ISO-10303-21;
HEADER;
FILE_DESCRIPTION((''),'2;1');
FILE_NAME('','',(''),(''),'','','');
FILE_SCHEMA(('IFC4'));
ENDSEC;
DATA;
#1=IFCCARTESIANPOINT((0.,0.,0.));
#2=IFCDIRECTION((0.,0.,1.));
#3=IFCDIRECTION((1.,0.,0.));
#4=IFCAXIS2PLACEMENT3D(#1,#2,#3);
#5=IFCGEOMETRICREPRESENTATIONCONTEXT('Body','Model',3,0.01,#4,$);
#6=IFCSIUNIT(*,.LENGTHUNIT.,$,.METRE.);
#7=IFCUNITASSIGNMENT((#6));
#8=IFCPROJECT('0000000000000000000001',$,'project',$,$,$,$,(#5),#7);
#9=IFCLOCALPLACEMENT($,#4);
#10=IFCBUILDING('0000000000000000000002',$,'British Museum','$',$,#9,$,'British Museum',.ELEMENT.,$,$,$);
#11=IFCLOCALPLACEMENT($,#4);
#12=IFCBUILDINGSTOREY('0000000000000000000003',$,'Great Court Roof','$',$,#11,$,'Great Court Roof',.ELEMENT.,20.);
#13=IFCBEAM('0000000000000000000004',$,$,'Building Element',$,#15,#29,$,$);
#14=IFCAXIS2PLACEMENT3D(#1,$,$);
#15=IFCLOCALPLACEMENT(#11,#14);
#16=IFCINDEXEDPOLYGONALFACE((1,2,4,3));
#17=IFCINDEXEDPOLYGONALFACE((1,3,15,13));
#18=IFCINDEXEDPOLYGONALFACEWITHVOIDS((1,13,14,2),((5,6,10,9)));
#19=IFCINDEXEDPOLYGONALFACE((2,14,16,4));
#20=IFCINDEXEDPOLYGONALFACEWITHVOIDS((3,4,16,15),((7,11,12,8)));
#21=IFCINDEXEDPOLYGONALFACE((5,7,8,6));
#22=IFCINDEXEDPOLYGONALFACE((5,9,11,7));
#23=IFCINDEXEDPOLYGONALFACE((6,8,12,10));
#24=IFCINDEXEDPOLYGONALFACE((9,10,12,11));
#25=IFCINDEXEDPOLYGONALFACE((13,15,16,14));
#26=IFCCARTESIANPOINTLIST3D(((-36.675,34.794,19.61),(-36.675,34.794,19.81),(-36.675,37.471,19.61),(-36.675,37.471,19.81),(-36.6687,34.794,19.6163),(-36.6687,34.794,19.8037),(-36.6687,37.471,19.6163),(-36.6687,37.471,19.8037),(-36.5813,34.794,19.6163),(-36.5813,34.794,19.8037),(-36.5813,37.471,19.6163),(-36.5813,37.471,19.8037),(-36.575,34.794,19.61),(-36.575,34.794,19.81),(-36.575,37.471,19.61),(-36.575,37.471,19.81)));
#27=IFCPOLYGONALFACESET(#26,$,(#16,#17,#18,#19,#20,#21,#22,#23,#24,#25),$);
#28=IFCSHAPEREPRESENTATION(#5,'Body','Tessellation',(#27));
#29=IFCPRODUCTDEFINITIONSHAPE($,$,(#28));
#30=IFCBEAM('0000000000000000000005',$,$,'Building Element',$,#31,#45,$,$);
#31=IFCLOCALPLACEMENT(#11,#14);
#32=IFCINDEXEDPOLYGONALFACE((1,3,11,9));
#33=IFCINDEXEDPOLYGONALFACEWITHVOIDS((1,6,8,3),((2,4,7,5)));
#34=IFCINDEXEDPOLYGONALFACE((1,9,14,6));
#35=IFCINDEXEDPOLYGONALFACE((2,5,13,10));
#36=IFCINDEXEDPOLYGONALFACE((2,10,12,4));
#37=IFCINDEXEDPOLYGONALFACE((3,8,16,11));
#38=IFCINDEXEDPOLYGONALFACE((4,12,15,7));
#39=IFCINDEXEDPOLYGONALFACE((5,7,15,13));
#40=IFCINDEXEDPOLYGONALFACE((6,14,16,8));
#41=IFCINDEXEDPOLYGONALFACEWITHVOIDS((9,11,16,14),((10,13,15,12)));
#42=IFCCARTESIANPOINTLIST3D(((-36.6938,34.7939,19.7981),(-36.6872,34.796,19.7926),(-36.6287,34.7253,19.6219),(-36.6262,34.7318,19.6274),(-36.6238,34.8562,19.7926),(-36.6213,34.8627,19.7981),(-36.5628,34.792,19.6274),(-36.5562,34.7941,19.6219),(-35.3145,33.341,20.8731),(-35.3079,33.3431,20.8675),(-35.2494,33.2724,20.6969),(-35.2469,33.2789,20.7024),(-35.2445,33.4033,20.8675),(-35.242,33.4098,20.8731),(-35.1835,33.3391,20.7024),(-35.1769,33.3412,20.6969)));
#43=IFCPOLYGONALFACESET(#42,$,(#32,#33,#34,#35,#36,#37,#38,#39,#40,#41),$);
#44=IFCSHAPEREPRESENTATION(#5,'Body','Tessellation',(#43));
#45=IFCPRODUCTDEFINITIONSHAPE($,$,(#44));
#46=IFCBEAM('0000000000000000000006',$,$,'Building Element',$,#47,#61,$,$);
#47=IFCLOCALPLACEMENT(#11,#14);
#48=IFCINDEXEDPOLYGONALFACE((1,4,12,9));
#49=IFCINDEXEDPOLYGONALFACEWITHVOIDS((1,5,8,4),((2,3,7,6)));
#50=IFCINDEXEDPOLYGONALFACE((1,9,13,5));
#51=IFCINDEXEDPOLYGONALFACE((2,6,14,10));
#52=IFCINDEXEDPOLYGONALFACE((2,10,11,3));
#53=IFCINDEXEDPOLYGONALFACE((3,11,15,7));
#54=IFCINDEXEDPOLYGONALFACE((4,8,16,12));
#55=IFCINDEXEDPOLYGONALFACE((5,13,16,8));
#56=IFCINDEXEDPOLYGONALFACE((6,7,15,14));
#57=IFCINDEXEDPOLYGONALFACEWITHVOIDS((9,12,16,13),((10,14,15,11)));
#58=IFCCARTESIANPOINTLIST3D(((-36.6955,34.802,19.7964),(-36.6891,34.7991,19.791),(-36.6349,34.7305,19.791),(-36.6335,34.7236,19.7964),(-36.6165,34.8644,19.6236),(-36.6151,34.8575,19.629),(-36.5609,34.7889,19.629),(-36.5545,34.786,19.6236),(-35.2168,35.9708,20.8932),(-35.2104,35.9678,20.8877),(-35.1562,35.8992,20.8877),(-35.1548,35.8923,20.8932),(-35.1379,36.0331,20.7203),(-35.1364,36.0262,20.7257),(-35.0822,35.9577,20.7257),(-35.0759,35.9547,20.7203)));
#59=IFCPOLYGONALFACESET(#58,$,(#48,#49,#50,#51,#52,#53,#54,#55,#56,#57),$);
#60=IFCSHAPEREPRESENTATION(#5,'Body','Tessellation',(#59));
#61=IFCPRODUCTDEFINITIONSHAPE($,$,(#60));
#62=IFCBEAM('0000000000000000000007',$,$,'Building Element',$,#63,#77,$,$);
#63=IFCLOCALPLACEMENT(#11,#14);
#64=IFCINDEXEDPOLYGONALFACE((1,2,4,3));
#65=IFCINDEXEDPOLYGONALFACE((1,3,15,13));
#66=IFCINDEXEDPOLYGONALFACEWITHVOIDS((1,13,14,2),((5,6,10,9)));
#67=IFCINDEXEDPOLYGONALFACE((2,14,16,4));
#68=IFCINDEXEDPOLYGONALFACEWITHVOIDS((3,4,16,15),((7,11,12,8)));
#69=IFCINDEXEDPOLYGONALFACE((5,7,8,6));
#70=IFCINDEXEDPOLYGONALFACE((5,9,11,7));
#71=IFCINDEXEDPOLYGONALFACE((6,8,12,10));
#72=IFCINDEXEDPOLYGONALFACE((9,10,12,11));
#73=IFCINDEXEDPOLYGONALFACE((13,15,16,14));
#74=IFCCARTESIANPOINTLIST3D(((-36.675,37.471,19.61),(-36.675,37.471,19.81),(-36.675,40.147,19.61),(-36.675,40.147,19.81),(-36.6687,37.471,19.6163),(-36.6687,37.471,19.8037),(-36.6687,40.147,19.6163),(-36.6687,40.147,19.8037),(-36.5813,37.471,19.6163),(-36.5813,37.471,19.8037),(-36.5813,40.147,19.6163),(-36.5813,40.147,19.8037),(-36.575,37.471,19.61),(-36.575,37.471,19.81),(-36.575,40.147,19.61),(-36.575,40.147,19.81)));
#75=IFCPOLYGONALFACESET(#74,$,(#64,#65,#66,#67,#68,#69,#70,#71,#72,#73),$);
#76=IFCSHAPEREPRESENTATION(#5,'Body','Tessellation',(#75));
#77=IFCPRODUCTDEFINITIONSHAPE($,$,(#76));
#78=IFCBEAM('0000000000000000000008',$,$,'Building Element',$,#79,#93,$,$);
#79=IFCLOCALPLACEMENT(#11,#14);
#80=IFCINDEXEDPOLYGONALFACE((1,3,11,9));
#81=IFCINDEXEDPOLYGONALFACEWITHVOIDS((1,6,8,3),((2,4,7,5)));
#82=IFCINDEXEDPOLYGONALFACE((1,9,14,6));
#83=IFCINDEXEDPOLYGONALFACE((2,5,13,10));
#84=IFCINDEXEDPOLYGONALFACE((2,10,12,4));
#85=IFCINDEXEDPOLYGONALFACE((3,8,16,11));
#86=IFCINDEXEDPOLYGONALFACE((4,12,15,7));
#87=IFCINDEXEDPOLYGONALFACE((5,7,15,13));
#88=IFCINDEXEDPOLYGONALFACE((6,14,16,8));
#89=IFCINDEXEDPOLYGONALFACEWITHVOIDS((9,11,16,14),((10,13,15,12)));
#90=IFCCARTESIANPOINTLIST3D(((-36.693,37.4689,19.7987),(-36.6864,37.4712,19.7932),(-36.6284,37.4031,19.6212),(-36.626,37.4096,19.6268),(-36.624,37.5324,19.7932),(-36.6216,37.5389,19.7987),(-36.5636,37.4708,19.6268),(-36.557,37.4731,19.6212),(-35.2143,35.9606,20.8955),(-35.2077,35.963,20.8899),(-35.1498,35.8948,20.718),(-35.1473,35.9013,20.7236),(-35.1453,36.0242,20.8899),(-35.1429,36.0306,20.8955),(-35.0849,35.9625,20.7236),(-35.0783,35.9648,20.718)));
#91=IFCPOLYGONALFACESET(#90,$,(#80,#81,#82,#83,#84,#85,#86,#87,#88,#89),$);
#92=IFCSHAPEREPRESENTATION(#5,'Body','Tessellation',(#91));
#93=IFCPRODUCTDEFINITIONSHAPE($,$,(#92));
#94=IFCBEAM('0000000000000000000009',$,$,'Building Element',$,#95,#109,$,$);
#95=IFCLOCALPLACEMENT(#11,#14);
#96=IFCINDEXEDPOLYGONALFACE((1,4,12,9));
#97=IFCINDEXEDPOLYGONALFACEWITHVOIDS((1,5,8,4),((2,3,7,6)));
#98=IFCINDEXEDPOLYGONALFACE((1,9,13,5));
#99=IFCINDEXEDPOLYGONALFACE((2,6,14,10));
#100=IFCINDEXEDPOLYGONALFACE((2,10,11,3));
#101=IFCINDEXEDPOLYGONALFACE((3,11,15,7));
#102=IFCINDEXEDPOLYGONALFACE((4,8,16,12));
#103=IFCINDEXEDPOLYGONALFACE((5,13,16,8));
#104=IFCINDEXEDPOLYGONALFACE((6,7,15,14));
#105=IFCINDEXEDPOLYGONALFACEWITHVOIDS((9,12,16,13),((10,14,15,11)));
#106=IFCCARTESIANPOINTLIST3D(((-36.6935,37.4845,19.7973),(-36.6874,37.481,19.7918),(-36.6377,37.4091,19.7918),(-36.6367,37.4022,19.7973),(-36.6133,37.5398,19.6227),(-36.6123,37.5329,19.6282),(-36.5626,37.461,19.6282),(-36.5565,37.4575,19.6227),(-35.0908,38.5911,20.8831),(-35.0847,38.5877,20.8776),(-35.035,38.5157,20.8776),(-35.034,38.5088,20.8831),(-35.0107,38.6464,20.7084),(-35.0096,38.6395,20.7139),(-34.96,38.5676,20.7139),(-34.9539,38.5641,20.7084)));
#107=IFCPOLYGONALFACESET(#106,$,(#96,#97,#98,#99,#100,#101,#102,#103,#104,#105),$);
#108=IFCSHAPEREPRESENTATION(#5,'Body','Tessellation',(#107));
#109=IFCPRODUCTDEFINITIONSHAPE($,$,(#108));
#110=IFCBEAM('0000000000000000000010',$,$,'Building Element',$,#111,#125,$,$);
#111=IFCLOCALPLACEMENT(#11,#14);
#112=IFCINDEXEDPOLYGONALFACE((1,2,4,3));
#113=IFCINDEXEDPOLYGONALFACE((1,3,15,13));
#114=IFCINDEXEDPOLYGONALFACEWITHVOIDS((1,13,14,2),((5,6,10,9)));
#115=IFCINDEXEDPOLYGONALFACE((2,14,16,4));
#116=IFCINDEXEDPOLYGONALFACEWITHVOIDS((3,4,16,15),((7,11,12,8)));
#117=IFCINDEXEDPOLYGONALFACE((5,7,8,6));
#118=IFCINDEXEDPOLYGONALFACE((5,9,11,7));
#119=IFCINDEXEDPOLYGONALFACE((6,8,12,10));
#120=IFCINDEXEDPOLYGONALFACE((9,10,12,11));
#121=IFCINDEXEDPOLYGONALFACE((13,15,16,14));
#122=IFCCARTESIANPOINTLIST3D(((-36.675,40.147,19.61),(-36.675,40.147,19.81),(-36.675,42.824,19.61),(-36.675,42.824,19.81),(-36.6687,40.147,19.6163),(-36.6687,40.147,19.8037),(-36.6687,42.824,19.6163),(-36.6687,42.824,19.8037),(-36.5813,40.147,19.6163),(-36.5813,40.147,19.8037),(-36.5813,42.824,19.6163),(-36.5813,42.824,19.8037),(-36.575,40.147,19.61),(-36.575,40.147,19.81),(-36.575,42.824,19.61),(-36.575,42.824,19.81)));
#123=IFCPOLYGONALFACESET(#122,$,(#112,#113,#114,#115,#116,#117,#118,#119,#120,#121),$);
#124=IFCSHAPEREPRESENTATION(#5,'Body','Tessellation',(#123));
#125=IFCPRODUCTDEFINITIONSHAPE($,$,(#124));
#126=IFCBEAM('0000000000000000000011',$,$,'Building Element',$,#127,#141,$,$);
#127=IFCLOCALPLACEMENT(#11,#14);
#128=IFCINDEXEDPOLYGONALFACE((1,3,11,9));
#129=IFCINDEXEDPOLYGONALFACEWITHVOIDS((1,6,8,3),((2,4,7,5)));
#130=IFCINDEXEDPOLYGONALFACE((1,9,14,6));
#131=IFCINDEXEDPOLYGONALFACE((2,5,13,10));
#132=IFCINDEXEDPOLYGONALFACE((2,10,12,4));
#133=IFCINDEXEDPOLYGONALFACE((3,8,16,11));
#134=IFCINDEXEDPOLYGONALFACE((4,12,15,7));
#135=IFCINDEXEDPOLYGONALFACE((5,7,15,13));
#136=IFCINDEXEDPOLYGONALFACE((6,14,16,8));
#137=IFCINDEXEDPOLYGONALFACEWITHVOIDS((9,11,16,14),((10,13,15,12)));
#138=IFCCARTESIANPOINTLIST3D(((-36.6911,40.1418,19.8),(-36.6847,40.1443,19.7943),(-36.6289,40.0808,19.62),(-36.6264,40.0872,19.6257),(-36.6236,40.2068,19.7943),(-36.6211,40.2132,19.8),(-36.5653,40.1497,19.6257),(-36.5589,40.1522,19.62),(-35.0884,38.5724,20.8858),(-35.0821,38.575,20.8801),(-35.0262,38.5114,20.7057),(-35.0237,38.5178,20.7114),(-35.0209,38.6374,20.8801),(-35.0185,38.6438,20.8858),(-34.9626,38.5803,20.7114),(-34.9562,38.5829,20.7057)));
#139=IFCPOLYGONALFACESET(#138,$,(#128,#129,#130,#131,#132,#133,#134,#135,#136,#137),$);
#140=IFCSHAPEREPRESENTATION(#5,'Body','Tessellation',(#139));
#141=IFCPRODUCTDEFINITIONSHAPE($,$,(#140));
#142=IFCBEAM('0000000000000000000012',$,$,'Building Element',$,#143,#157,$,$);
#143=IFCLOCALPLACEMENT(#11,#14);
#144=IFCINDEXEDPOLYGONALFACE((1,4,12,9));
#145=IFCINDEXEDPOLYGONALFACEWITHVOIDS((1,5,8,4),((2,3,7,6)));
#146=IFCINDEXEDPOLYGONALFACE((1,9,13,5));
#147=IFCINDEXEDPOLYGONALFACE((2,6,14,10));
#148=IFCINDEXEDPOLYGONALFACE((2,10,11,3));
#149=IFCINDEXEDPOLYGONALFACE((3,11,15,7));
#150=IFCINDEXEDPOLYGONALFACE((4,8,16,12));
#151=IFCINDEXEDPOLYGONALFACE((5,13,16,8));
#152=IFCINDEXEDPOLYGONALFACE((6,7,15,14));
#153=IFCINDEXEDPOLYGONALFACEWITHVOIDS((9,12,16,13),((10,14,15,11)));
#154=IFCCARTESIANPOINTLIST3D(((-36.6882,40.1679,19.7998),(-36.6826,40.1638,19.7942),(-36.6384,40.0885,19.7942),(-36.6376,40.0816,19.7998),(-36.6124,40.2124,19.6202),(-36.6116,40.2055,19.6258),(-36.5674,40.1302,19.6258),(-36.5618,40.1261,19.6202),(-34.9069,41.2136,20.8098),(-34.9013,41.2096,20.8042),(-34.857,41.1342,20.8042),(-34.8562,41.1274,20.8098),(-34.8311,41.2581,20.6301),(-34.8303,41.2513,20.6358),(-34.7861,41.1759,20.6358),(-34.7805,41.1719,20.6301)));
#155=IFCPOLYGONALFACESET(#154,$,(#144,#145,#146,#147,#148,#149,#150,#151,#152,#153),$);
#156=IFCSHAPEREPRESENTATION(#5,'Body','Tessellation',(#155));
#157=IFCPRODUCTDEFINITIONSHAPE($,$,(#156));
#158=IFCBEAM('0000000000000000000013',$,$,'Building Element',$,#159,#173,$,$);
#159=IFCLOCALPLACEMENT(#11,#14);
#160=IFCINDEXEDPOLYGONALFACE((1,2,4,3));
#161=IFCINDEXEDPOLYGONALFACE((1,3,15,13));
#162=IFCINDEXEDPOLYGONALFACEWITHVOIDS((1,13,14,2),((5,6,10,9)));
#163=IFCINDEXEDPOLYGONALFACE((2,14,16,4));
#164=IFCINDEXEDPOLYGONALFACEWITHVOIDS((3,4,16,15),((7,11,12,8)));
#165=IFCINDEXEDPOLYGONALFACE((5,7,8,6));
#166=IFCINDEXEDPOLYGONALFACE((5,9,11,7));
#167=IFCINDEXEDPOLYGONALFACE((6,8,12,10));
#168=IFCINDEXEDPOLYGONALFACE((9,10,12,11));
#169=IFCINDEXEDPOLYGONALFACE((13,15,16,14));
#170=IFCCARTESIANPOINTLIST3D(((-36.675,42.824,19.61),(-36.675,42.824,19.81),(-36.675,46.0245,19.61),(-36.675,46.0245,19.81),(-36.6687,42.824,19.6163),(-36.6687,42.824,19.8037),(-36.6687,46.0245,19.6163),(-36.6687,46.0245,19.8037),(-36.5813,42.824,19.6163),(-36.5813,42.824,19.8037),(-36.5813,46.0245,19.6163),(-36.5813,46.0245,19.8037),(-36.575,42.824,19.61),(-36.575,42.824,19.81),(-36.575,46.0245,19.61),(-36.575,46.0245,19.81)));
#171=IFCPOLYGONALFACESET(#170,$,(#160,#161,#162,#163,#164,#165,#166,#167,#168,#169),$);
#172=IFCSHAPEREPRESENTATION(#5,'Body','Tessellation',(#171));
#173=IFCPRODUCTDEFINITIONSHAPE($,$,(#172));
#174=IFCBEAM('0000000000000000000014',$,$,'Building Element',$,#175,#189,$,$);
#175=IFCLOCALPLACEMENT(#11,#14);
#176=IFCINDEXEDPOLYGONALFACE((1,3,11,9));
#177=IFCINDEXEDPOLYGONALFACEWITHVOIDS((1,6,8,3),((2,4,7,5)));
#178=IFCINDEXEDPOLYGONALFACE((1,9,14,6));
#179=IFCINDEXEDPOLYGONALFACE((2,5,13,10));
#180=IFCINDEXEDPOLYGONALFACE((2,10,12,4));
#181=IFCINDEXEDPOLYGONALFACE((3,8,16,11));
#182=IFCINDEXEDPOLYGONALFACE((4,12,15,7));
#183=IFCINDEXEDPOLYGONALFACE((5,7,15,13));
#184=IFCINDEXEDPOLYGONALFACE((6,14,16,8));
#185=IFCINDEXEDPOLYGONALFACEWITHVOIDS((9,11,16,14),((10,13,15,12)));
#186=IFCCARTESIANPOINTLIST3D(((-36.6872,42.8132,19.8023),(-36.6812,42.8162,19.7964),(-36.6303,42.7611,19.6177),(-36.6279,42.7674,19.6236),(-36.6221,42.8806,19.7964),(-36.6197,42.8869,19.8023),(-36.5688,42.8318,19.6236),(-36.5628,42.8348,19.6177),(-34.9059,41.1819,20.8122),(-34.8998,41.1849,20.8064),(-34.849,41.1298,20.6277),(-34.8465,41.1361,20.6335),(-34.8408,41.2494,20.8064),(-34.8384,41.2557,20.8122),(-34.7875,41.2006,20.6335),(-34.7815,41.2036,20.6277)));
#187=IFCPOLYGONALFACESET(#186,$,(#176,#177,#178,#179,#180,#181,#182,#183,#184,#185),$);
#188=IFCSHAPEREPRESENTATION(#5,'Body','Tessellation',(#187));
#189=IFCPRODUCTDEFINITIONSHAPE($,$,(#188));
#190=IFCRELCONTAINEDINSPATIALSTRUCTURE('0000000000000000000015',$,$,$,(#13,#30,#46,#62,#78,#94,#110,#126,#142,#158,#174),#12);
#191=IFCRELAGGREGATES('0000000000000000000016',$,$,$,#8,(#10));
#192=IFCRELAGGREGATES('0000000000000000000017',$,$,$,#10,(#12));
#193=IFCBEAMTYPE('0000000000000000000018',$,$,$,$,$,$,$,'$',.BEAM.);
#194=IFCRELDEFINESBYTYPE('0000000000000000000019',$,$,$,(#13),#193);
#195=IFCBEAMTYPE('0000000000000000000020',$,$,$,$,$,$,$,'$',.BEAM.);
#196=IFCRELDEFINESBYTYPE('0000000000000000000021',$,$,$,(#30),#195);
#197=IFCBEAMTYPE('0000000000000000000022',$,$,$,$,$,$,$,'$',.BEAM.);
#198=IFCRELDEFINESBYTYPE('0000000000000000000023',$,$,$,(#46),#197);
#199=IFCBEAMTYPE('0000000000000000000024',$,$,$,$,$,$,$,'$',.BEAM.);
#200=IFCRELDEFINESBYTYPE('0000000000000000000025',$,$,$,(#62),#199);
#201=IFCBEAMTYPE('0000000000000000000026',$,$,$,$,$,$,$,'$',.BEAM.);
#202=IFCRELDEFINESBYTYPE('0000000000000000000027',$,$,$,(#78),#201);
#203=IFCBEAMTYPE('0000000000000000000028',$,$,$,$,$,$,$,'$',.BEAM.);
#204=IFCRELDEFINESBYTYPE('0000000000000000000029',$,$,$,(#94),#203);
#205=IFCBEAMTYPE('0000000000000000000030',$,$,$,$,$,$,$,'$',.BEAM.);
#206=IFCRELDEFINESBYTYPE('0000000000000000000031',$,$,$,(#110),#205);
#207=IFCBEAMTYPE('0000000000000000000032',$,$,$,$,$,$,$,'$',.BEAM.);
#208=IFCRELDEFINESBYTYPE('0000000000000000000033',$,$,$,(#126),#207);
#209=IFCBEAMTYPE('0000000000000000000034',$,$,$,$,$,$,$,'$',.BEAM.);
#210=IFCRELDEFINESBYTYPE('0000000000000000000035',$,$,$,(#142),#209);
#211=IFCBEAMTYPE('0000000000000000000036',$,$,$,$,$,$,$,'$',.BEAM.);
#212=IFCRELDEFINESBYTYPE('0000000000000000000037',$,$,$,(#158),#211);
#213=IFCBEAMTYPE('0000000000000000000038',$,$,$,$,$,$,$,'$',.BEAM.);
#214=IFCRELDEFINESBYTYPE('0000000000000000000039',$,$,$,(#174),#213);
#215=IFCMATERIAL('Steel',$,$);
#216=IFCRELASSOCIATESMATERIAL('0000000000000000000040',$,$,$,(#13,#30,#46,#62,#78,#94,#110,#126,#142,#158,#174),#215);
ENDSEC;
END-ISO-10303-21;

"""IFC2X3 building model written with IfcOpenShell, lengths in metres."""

from ifc_helpers import new_model, si_unit, frame, origin_with_axes, origin_2d, place, context, project, spatial, hollow_rectangle, extrude, material, type_object, element, save


model = new_model("IFC2X3")

# Units and contexts
model_context = context("Model", 3, precision=0.01, world=origin_with_axes(), identifier="Body")
ifc_project = project(units=[si_unit("LENGTHUNIT", "METRE")], contexts=[model_context])

# Building, storey
building_placement = place(None, origin_with_axes())
building = spatial("IfcBuilding", under=ifc_project, at=building_placement, Name="British Museum", Description="$", LongName="British Museum", CompositionType="ELEMENT")
storey_placement = place(None, origin_with_axes())
storey = spatial("IfcBuildingStorey", under=building, at=storey_placement, Name="Great Court Roof", Description="$", LongName="Great Court Roof", CompositionType="ELEMENT", Elevation=20.0)

# Beams
ifc_material = material(Name="Steel")
beam_type_1 = type_object("IfcBeamType", ElementType="$", PredefinedType="BEAM")
beam_1_placement = place(None, origin_with_axes())
element("IfcBeam", 1, at=beam_1_placement, inside=storey, type_object=beam_type_1, material=ifc_material, Description="Building Element", context=model_context, shape_type="SweptSolid", body=[
    extrude(hollow_rectangle(XDim=0.1, YDim=0.2, WallThickness=0.0063, InnerFilletRadius=-0.0063, OuterFilletRadius=0.0, at=origin_2d()), frame((-36.625, 34.794, 19.71), z_axis=(0.0, 1.0, 0.0), x_axis=(-1.0, 0.0, 0.0)), (0.0, 0.0, 1.0), 2.677),
])
beam_type_2 = type_object("IfcBeamType", ElementType="$", PredefinedType="BEAM")
beam_2_placement = place(None, origin_with_axes())
element("IfcBeam", 2, at=beam_2_placement, inside=storey, type_object=beam_type_2, material=ifc_material, Description="Building Element", context=model_context, shape_type="SweptSolid", body=[
    extrude(hollow_rectangle(XDim=0.1, YDim=0.2, WallThickness=0.0063, InnerFilletRadius=-0.0063, OuterFilletRadius=0.0, at=origin_2d()), frame((-36.625, 34.794, 19.71), z_axis=(0.606687, -0.639042, 0.472818), x_axis=(0.725228, 0.688509, 0.0)), (0.0, 0.0, 1.0), 2.2735),
])
beam_type_3 = type_object("IfcBeamType", ElementType="$", PredefinedType="BEAM")
beam_3_placement = place(None, origin_with_axes())
element("IfcBeam", 3, at=beam_3_placement, inside=storey, type_object=beam_type_3, material=ifc_material, Description="Building Element", context=model_context, shape_type="SweptSolid", body=[
    extrude(hollow_rectangle(XDim=0.1, YDim=0.2, WallThickness=0.0063, InnerFilletRadius=-0.0063, OuterFilletRadius=0.0, at=origin_2d()), frame((-36.625, 34.794, 19.71), z_axis=(0.678093, 0.535954, 0.502935), x_axis=(-0.620084, 0.784535, 0.0)), (0.0, 0.0, 1.0), 2.1807),
])
beam_type_4 = type_object("IfcBeamType", ElementType="$", PredefinedType="BEAM")
beam_4_placement = place(None, origin_with_axes())
element("IfcBeam", 4, at=beam_4_placement, inside=storey, type_object=beam_type_4, material=ifc_material, Description="Building Element", context=model_context, shape_type="SweptSolid", body=[
    extrude(hollow_rectangle(XDim=0.1, YDim=0.2, WallThickness=0.0063, InnerFilletRadius=-0.0063, OuterFilletRadius=0.0, at=origin_2d()), frame((-36.625, 37.471, 19.71), z_axis=(0.0, 1.0, 0.0), x_axis=(-1.0, 0.0, 0.0)), (0.0, 0.0, 1.0), 2.676),
])
beam_type_5 = type_object("IfcBeamType", ElementType="$", PredefinedType="BEAM")
beam_5_placement = place(None, origin_with_axes())
element("IfcBeam", 5, at=beam_5_placement, inside=storey, type_object=beam_type_5, material=ifc_material, Description="Building Element", context=model_context, shape_type="SweptSolid", body=[
    extrude(hollow_rectangle(XDim=0.1, YDim=0.2, WallThickness=0.0063, InnerFilletRadius=-0.0063, OuterFilletRadius=0.0, at=origin_2d()), frame((-36.625, 37.471, 19.71), z_axis=(0.621307, -0.633738, 0.460818), x_axis=(0.714075, 0.700069, 0.0)), (0.0, 0.0, 1.0), 2.38),
])
beam_type_6 = type_object("IfcBeamType", ElementType="$", PredefinedType="BEAM")
beam_6_placement = place(None, origin_with_axes())
element("IfcBeam", 6, at=beam_6_placement, inside=storey, type_object=beam_type_6, material=ifc_material, Description="Building Element", context=model_context, shape_type="SweptSolid", body=[
    extrude(hollow_rectangle(XDim=0.1, YDim=0.2, WallThickness=0.0063, InnerFilletRadius=-0.0063, OuterFilletRadius=0.0, at=origin_2d()), frame((-36.625, 37.471, 19.71), z_axis=(0.718752, 0.496287, 0.486924), x_axis=(-0.568195, 0.822894, 0.0)), (0.0, 0.0, 1.0), 2.2298),
])
beam_type_7 = type_object("IfcBeamType", ElementType="$", PredefinedType="BEAM")
beam_7_placement = place(None, origin_with_axes())
element("IfcBeam", 7, at=beam_7_placement, inside=storey, type_object=beam_type_7, material=ifc_material, Description="Building Element", context=model_context, shape_type="SweptSolid", body=[
    extrude(hollow_rectangle(XDim=0.1, YDim=0.2, WallThickness=0.0063, InnerFilletRadius=-0.0063, OuterFilletRadius=0.0, at=origin_2d()), frame((-36.625, 40.147, 19.71), z_axis=(0.0, 1.0, 0.0), x_axis=(-1.0, 0.0, 0.0)), (0.0, 0.0, 1.0), 2.677),
])
beam_type_8 = type_object("IfcBeamType", ElementType="$", PredefinedType="BEAM")
beam_8_placement = place(None, origin_with_axes())
element("IfcBeam", 8, at=beam_8_placement, inside=storey, type_object=beam_type_8, material=ifc_material, Description="Building Element", context=model_context, shape_type="SweptSolid", body=[
    extrude(hollow_rectangle(XDim=0.1, YDim=0.2, WallThickness=0.0063, InnerFilletRadius=-0.0063, OuterFilletRadius=0.0, at=origin_2d()), frame((-36.625, 40.147, 19.71), z_axis=(0.643111, -0.629754, 0.435681), x_axis=(0.699648, 0.714488, 0.0)), (0.0, 0.0, 1.0), 2.4921),
])
beam_type_9 = type_object("IfcBeamType", ElementType="$", PredefinedType="BEAM")
beam_9_placement = place(None, origin_with_axes())
element("IfcBeam", 9, at=beam_9_placement, inside=storey, type_object=beam_type_9, material=ifc_material, Description="Building Element", context=model_context, shape_type="SweptSolid", body=[
    extrude(hollow_rectangle(XDim=0.1, YDim=0.2, WallThickness=0.0063, InnerFilletRadius=-0.0063, OuterFilletRadius=0.0, at=origin_2d()), frame((-36.625, 40.147, 19.71), z_axis=(0.774727, 0.454812, 0.439255), x_axis=(-0.506267, 0.862377, 0.0)), (0.0, 0.0, 1.0), 2.2993),
])
beam_type_10 = type_object("IfcBeamType", ElementType="$", PredefinedType="BEAM")
beam_10_placement = place(None, origin_with_axes())
element("IfcBeam", 10, at=beam_10_placement, inside=storey, type_object=beam_type_10, material=ifc_material, Description="Building Element", context=model_context, shape_type="SweptSolid", body=[
    extrude(hollow_rectangle(XDim=0.1, YDim=0.2, WallThickness=0.0063, InnerFilletRadius=-0.0063, OuterFilletRadius=0.0, at=origin_2d()), frame((-36.625, 42.824, 19.71), z_axis=(0.0, 1.0, 0.0), x_axis=(-1.0, 0.0, 0.0)), (0.0, 0.0, 1.0), 3.2005),
])
beam_type_11 = type_object("IfcBeamType", ElementType="$", PredefinedType="BEAM")
beam_11_placement = place(None, origin_with_axes())
element("IfcBeam", 11, at=beam_11_placement, inside=storey, type_object=beam_type_11, material=ifc_material, Description="Building Element", context=model_context, shape_type="SweptSolid", body=[
    extrude(hollow_rectangle(XDim=0.1, YDim=0.2, WallThickness=0.0063, InnerFilletRadius=-0.0063, OuterFilletRadius=0.0, at=origin_2d()), frame((-36.625, 42.824, 19.71), z_axis=(0.680403, -0.623081, 0.385775), x_axis=(0.675359, 0.737489, 0.0)), (0.0, 0.0, 1.0), 2.618),
])

save(model, "model.ifc")
